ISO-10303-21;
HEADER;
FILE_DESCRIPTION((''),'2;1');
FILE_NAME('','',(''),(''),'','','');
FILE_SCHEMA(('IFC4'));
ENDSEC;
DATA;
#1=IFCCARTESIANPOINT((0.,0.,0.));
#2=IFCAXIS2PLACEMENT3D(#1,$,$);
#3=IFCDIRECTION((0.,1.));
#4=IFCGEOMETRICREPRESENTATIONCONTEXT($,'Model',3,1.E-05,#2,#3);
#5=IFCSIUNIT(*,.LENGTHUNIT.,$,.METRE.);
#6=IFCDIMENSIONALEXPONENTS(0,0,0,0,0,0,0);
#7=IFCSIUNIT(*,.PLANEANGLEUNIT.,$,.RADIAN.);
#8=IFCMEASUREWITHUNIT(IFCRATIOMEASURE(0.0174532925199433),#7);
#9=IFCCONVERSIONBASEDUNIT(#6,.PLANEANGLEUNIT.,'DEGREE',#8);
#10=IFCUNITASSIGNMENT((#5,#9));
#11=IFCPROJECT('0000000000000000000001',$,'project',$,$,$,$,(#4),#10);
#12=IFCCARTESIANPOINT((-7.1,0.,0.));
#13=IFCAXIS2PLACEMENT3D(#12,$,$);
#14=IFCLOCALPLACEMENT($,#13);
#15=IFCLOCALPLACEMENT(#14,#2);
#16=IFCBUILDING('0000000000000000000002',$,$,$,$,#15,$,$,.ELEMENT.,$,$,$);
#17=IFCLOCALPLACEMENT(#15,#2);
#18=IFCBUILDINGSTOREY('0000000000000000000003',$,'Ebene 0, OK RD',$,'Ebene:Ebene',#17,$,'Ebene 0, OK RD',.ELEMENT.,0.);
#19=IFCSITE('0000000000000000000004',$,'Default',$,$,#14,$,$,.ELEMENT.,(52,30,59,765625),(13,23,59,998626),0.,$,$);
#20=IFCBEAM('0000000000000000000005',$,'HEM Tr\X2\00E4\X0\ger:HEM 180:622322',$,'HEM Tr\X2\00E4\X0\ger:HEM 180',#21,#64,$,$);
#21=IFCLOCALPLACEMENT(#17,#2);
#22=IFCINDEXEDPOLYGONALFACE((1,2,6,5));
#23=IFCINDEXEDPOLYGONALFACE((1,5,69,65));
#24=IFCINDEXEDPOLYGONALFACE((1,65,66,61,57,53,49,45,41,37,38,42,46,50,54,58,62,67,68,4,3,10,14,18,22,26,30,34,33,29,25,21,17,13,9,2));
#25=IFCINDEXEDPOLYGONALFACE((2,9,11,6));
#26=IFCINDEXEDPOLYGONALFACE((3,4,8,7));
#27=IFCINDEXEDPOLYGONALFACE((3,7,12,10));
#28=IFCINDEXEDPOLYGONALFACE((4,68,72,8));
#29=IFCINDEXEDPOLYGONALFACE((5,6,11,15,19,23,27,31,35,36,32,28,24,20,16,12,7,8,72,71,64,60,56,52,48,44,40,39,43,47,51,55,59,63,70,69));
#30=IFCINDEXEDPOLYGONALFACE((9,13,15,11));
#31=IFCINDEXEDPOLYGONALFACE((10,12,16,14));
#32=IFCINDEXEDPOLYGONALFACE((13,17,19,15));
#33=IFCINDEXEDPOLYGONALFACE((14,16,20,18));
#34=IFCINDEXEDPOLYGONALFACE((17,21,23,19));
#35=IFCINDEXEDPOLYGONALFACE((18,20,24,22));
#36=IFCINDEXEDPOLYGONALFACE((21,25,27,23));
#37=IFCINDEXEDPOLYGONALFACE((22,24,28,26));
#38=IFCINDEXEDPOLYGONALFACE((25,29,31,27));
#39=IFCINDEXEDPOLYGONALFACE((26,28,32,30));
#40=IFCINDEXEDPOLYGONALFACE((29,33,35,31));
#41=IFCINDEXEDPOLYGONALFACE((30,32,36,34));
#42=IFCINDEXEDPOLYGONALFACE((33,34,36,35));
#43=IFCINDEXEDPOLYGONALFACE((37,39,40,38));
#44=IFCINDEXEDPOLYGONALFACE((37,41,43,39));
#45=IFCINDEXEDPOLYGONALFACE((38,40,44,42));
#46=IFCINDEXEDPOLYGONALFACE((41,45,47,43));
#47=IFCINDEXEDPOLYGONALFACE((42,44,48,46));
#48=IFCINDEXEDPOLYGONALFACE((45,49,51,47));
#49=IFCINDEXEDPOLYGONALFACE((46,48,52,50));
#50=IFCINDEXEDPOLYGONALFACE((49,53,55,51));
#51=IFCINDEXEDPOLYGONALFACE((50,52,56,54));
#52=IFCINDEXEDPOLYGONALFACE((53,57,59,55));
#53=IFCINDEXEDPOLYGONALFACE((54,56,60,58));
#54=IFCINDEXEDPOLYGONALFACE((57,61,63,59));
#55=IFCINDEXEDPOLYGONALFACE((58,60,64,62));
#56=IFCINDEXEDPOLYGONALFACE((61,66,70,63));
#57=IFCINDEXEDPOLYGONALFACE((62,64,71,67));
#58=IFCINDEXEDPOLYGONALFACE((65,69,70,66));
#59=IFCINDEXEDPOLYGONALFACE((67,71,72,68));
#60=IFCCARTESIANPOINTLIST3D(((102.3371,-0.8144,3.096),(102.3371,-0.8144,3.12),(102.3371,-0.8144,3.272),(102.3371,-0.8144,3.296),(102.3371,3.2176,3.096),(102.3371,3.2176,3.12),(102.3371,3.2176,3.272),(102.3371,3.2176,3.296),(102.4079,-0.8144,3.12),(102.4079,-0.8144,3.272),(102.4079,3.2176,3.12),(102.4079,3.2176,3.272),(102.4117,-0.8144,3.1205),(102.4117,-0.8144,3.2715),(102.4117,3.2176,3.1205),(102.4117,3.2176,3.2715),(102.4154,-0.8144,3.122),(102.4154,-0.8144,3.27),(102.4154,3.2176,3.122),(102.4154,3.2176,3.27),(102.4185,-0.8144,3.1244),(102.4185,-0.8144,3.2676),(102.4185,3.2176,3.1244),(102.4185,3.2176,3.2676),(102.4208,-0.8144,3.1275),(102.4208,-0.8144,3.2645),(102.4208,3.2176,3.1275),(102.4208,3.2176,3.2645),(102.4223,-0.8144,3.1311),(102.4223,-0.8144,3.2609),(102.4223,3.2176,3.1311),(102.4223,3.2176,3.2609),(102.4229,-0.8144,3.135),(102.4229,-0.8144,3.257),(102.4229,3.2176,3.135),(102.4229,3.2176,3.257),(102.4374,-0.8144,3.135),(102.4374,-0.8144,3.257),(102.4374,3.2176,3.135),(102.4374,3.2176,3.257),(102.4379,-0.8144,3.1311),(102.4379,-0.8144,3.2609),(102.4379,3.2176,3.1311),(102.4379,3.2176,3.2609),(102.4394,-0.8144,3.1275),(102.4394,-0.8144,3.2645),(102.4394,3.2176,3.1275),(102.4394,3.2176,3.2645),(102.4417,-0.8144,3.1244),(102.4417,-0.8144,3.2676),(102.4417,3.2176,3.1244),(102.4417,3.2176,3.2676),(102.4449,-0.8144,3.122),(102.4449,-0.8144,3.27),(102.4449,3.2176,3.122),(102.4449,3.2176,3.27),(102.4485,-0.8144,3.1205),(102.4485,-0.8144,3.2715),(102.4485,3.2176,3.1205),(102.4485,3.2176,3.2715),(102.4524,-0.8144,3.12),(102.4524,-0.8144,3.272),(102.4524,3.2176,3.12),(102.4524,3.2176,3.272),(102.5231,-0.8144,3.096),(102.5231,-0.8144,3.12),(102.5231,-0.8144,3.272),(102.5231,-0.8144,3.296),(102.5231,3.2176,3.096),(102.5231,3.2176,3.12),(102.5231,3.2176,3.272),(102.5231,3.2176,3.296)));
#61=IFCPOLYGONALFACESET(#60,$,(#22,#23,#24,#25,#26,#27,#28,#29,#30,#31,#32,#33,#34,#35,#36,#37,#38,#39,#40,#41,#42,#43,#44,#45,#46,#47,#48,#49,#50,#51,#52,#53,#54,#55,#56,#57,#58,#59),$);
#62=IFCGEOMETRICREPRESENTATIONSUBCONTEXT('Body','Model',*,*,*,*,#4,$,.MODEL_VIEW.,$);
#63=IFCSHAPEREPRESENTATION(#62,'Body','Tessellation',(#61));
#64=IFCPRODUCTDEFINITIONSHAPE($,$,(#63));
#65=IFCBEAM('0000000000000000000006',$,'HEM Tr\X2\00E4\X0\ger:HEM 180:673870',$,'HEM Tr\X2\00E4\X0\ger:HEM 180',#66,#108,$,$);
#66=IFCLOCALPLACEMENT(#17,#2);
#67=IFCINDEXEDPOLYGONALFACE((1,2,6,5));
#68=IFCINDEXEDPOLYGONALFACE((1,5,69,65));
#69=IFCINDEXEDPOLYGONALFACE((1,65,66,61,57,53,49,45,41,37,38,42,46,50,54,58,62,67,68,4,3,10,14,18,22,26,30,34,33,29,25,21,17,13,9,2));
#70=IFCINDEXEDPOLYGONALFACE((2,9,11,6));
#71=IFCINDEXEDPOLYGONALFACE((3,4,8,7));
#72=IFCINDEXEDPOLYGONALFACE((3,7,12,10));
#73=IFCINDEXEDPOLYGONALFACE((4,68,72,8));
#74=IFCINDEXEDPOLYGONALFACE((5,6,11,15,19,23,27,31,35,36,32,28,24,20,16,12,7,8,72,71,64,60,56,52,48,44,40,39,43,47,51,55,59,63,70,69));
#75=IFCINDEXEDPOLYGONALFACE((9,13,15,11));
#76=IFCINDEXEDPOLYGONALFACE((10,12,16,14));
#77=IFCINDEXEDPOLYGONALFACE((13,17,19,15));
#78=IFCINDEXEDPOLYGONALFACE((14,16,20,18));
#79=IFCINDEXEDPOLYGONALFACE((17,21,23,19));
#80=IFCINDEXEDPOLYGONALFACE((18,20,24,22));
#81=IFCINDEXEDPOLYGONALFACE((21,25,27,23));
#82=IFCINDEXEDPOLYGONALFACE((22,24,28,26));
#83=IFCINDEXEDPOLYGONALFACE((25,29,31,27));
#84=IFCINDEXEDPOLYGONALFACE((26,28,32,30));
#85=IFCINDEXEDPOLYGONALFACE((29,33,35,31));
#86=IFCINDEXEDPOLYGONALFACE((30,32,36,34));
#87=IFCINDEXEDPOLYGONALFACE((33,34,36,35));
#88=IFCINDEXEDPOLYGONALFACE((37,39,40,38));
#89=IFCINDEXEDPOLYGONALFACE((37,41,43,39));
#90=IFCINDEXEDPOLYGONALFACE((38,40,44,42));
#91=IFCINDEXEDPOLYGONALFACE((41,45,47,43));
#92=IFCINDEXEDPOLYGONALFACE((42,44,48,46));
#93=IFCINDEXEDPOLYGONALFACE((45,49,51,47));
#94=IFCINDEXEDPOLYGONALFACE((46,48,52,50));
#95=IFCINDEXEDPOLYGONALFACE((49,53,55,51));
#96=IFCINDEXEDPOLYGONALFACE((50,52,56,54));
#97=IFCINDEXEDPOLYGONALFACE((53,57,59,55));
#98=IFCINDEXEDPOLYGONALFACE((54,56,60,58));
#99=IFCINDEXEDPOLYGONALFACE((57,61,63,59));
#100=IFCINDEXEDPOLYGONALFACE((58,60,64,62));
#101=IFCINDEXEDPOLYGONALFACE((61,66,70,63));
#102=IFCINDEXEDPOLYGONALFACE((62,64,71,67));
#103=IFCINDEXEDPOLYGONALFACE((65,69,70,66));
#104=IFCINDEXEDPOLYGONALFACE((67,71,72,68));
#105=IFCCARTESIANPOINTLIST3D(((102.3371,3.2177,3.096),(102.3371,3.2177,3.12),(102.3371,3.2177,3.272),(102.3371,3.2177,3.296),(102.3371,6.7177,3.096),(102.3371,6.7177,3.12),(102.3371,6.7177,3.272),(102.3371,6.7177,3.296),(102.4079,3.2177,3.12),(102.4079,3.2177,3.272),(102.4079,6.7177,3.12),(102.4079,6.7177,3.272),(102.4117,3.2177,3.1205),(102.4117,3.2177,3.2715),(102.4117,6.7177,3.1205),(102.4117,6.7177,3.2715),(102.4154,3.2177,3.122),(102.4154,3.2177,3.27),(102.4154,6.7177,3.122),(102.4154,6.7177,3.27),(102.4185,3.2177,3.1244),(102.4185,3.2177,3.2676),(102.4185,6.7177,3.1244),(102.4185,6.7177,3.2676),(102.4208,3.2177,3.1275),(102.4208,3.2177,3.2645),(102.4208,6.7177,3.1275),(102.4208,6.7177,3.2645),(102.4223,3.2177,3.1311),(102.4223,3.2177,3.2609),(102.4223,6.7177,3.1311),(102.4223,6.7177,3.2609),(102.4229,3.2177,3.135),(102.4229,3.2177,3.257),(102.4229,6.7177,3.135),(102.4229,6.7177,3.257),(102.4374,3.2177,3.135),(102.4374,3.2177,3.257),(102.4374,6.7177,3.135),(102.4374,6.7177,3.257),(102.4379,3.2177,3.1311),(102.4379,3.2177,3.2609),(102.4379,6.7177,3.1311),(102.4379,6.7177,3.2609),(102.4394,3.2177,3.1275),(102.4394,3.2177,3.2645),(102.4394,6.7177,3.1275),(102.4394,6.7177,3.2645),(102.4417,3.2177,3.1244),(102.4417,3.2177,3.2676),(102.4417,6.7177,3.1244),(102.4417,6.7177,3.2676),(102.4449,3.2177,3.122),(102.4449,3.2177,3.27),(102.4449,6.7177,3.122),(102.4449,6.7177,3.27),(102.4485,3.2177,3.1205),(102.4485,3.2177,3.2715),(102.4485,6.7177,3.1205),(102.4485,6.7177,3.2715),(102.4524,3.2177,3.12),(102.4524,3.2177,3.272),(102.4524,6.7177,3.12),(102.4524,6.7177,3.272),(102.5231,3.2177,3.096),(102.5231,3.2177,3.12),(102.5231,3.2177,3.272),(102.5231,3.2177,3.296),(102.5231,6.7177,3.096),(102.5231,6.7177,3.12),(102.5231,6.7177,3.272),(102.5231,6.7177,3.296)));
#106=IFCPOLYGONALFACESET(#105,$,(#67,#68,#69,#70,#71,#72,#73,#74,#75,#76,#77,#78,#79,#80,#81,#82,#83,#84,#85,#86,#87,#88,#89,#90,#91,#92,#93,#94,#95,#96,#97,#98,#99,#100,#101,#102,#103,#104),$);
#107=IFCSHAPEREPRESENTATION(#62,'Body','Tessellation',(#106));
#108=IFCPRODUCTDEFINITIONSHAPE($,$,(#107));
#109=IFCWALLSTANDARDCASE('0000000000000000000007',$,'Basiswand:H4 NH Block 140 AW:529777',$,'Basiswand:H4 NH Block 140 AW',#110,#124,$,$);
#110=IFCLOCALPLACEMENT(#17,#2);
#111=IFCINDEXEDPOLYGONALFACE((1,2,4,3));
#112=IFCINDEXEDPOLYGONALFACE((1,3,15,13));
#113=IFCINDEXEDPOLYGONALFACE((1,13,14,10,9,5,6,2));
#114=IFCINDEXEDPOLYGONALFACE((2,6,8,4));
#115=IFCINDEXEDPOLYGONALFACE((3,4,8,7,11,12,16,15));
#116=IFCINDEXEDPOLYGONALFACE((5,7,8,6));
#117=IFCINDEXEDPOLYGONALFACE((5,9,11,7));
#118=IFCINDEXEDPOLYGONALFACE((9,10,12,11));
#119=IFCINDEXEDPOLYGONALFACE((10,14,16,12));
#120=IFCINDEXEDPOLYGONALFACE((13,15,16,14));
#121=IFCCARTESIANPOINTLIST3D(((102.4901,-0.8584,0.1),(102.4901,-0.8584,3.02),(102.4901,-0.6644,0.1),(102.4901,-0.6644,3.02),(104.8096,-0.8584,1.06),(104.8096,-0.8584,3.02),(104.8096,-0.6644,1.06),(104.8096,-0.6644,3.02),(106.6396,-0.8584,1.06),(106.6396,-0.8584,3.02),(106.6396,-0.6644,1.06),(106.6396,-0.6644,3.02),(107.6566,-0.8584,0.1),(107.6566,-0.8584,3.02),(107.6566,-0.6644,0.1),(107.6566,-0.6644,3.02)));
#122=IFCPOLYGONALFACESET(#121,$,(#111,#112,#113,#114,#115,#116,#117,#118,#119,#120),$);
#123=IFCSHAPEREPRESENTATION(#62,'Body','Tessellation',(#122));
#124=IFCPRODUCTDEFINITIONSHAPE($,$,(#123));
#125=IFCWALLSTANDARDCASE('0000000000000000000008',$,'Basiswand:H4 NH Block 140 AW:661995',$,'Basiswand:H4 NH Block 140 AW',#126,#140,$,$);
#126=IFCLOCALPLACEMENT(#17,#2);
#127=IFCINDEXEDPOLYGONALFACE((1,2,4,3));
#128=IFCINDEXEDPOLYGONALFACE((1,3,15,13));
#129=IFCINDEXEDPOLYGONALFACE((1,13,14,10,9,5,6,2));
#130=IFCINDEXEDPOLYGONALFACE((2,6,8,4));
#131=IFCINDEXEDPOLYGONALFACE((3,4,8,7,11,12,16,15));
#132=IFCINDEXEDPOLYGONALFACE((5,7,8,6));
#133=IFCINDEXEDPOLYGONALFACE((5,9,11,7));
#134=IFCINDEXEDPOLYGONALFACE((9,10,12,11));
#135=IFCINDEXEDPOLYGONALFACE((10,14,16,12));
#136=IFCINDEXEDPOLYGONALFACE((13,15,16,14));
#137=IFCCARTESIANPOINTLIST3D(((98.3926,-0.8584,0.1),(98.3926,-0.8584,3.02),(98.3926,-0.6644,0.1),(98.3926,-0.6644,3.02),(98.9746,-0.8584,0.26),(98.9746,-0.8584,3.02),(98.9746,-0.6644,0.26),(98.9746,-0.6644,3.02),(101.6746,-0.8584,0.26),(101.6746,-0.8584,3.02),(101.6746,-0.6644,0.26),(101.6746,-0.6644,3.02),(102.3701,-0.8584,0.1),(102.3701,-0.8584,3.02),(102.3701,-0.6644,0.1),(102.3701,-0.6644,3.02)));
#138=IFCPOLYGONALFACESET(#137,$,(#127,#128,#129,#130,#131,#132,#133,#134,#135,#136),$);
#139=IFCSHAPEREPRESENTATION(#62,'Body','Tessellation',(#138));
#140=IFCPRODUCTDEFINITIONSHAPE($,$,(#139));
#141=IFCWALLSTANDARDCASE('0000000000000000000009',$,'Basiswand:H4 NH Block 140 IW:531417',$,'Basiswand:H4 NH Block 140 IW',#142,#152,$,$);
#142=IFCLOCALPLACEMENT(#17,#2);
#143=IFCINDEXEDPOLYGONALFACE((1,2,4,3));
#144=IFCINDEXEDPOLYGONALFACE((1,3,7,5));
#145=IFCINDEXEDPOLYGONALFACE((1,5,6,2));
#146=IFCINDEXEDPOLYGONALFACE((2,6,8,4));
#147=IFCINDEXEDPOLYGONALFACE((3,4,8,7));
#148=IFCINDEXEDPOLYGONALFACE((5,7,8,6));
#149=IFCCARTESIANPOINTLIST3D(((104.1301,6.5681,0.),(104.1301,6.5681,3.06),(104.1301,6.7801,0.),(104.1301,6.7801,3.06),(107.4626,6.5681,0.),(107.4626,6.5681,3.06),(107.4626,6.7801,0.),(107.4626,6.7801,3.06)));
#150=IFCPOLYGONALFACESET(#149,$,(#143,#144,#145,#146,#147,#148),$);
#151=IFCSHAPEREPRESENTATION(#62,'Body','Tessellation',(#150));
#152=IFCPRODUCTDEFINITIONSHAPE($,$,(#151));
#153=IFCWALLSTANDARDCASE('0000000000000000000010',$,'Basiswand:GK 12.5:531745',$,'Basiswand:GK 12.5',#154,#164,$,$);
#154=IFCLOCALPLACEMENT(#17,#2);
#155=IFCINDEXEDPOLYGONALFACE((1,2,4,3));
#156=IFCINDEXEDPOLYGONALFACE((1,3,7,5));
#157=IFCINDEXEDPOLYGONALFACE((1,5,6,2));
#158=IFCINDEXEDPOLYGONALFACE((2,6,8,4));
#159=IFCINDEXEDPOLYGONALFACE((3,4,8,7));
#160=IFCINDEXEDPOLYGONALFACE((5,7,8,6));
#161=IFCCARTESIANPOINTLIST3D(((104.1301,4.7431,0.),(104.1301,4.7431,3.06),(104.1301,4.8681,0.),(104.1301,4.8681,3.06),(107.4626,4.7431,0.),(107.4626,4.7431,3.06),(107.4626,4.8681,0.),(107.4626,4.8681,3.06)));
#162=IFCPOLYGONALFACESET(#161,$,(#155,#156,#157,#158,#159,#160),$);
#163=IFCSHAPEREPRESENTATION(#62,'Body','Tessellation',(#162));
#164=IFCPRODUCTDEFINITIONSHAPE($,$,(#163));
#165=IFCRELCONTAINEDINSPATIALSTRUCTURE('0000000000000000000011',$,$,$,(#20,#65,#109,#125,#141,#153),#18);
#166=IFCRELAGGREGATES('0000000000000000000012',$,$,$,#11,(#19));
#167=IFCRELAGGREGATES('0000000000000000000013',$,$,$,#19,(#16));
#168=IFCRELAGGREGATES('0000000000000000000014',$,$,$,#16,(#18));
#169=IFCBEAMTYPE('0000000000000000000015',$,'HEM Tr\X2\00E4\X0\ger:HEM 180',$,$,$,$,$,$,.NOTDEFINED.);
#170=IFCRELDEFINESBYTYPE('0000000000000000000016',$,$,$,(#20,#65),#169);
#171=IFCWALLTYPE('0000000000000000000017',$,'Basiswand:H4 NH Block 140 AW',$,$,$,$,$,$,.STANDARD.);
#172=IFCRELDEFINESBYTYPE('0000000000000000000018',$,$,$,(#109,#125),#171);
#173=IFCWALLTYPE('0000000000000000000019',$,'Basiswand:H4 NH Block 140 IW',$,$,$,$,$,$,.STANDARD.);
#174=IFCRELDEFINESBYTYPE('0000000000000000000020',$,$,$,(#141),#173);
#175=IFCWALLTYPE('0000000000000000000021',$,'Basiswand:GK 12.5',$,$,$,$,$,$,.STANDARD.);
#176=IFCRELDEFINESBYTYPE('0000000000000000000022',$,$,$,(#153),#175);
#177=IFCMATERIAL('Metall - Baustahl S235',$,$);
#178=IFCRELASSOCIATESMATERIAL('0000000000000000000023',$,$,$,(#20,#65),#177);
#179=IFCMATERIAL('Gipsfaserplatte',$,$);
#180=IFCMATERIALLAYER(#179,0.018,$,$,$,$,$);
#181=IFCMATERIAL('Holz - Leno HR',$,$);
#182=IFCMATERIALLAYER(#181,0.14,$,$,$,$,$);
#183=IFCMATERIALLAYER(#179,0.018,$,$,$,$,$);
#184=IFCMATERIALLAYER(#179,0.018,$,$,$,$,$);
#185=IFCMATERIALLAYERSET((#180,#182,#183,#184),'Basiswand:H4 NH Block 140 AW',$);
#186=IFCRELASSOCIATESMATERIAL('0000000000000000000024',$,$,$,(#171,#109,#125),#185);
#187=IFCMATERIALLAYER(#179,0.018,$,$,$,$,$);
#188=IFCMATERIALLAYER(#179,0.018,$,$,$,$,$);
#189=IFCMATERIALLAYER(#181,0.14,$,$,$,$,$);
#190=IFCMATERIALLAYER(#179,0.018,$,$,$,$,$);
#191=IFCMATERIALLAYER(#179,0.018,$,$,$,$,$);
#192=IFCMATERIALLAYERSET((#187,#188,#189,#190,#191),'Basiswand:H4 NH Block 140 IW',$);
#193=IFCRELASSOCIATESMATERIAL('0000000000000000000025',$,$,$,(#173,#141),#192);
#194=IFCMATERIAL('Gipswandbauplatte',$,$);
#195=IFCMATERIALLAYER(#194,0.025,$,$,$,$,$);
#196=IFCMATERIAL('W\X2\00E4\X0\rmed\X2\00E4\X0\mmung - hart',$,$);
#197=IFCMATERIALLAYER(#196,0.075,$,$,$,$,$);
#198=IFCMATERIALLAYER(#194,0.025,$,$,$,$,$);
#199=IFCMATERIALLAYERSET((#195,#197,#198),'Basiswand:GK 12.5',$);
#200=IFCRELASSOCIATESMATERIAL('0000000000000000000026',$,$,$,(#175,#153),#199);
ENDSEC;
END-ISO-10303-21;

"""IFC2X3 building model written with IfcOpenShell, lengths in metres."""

from ifc_helpers import new_model, entity, si_unit, converted_unit, direction, frame, frame_2d, origin, origin_2d_with_axis, place, context, subcontext, project, spatial, rectangle, i_section, extrude, material, layer, layer_set, layer_usage, type_object, element, save


model = new_model("IFC2X3")

# Units and contexts
model_context = context("Model", 3, precision=1e-05, world=origin(), true_north=direction((0.0, 1.0)))
body_context = subcontext(model_context, "Body", "Model", "MODEL_VIEW")
ifc_project = project(units=[si_unit("LENGTHUNIT", "METRE"), converted_unit("PLANEANGLEUNIT", "DEGREE", entity("IfcRatioMeasure", 0.0174532925199433), si_unit("PLANEANGLEUNIT", "RADIAN"), dimensions=[0, 0, 0, 0, 0, 0, 0])], contexts=[model_context])

# Site, building, storey
site_placement = place(None, frame((-7.1, 0.0, 0.0)))
site = spatial("IfcSite", under=ifc_project, at=site_placement, Name="Default", CompositionType="ELEMENT", RefLatitude=(52, 30, 59, 765625), RefLongitude=(13, 23, 59, 998626), RefElevation=0.0)
building_placement = place(site_placement, origin())
building = spatial("IfcBuilding", under=site, at=building_placement, CompositionType="ELEMENT")
storey_placement = place(building_placement, origin())
storey = spatial("IfcBuildingStorey", under=building, at=storey_placement, Name="Ebene 0, OK RD", ObjectType="Ebene:Ebene", LongName="Ebene 0, OK RD", CompositionType="ELEMENT", Elevation=0.0)

# Shared definitions
ifc_material_1 = material(Name="Metall - Baustahl S235")

# Beams
beam_type = type_object("IfcBeamType", Name="HEM Träger:HEM 180", PredefinedType="NOTDEFINED")
beam_1_placement = place(storey_placement, frame((102.4301, -0.8144, 3.096), z_axis=(0.0, 0.0, 1.0), x_axis=(0.0, 1.0, 0.0)))
element("IfcBeam", 1, at=beam_1_placement, inside=storey, type_object=beam_type, material=ifc_material_1, Name="HEM Träger:HEM 180:622322", ObjectType="HEM Träger:HEM 180", context=body_context, shape_type="SweptSolid", body=[
    extrude(i_section(OverallWidth=0.186, OverallDepth=0.2, WebThickness=0.0145, FlangeThickness=0.024, FilletRadius=0.015, at=frame_2d((0.0, 0.0), x_axis=(0.0, 1.0))), frame((0.0, 0.0, 0.1), z_axis=(1.0, 0.0, 0.0), x_axis=(0.0, 0.0, -1.0)), (0.0, 0.0, 1.0), 4.032),
])
beam_2_placement = place(storey_placement, frame((102.4301, 3.2176, 3.096), z_axis=(0.0, 0.0, 1.0), x_axis=(0.0, 1.0, 0.0)))
element("IfcBeam", 2, at=beam_2_placement, inside=storey, type_object=beam_type, material=ifc_material_1, Name="HEM Träger:HEM 180:673870", ObjectType="HEM Träger:HEM 180", context=body_context, shape_type="SweptSolid", body=[
    extrude(i_section(OverallWidth=0.186, OverallDepth=0.2, WebThickness=0.0145, FlangeThickness=0.024, FilletRadius=0.015, at=frame_2d((0.0, 0.0), x_axis=(0.0, 1.0))), frame((0.0, 0.0, 0.1), z_axis=(1.0, 0.0, 0.0), x_axis=(0.0, 0.0, -1.0)), (0.0, 0.0, 1.0), 3.5),
])

# Walls, openings
ifc_material_2 = material(Name="Gipsfaserplatte")
ifc_layer_1 = layer(ifc_material_2, 0.018)
ifc_material_3 = material(Name="Holz - Leno HR")
ifc_layer_2 = layer(ifc_material_3, 0.14)
ifc_layer_3 = layer(ifc_material_2, 0.018)
ifc_layer_4 = layer(ifc_material_2, 0.018)
ifc_layer_set_1 = layer_set([ifc_layer_1, ifc_layer_2, ifc_layer_3, ifc_layer_4], Name="Basiswand:H4 NH Block 140 AW")
ifc_layer_usage_1 = layer_usage(ifc_layer_set_1, "AXIS2", "NEGATIVE", 0.097)
wall_type_1 = type_object("IfcWallType", Name="Basiswand:H4 NH Block 140 AW", PredefinedType="STANDARD", material=ifc_layer_set_1)
wall_1_placement = place(storey_placement, frame((107.6566, -0.7614, 0.1), z_axis=(0.0, 0.0, 1.0), x_axis=(-1.0, 0.0, 0.0)))
wall_1 = element("IfcWallStandardCase", 3, at=wall_1_placement, inside=storey, type_object=wall_type_1, material=ifc_layer_usage_1, Name="Basiswand:H4 NH Block 140 AW:529777", ObjectType="Basiswand:H4 NH Block 140 AW", context=body_context, shape_type="SweptSolid", body=[
    extrude(rectangle(XDim=5.1665, YDim=0.194, at=frame_2d((2.5833, 0.0), x_axis=(-1.0, 0.0))), origin(), (0.0, 0.0, 1.0), 2.92),
])
opening_1_placement = place(wall_1_placement, origin())
element("IfcOpeningElement", 4, at=opening_1_placement, cuts=wall_1, ObjectType="Opening", context=body_context, shape_type="SweptSolid", body=[
    extrude(rectangle(XDim=2.0, YDim=1.83, at=origin_2d_with_axis()), frame((1.932, -0.097, 1.96), z_axis=(0.0, 1.0, 0.0), x_axis=(0.0, 0.0, -1.0)), (0.0, 0.0, 1.0), 0.194),
])
ifc_layer_usage_2 = layer_usage(ifc_layer_set_1, "AXIS2", "NEGATIVE", 0.097)
wall_2_placement = place(storey_placement, frame((102.3701, -0.7614, 0.1), z_axis=(0.0, 0.0, 1.0), x_axis=(-1.0, 0.0, 0.0)))
wall_2 = element("IfcWallStandardCase", 5, at=wall_2_placement, inside=storey, type_object=wall_type_1, material=ifc_layer_usage_2, Name="Basiswand:H4 NH Block 140 AW:661995", ObjectType="Basiswand:H4 NH Block 140 AW", context=body_context, shape_type="SweptSolid", body=[
    extrude(rectangle(XDim=3.9775, YDim=0.194, at=frame_2d((1.9888, 0.0), x_axis=(-1.0, 0.0))), origin(), (0.0, 0.0, 1.0), 2.92),
])
opening_2_placement = place(wall_2_placement, origin())
element("IfcOpeningElement", 6, at=opening_2_placement, cuts=wall_2, ObjectType="Opening", context=body_context, shape_type="SweptSolid", body=[
    extrude(rectangle(XDim=2.8, YDim=2.7, at=origin_2d_with_axis()), frame((2.0455, -0.097, 1.56), z_axis=(0.0, 1.0, 0.0), x_axis=(0.0, 0.0, -1.0)), (0.0, 0.0, 1.0), 0.194),
])

# Walls
ifc_layer_5 = layer(ifc_material_2, 0.018)
ifc_layer_6 = layer(ifc_material_2, 0.018)
ifc_layer_7 = layer(ifc_material_3, 0.14)
ifc_layer_8 = layer(ifc_material_2, 0.018)
ifc_layer_9 = layer(ifc_material_2, 0.018)
ifc_layer_set_2 = layer_set([ifc_layer_5, ifc_layer_6, ifc_layer_7, ifc_layer_8, ifc_layer_9], Name="Basiswand:H4 NH Block 140 IW")
ifc_layer_usage_3 = layer_usage(ifc_layer_set_2, "AXIS2", "NEGATIVE", 0.106)
wall_type_2 = type_object("IfcWallType", Name="Basiswand:H4 NH Block 140 IW", PredefinedType="STANDARD", material=ifc_layer_set_2)
wall_3_placement = place(storey_placement, frame((104.1301, 6.6741, 0.0)))
element("IfcWallStandardCase", 7, at=wall_3_placement, inside=storey, type_object=wall_type_2, material=ifc_layer_usage_3, Name="Basiswand:H4 NH Block 140 IW:531417", ObjectType="Basiswand:H4 NH Block 140 IW", context=body_context, shape_type="SweptSolid", body=[
    extrude(rectangle(XDim=3.3325, YDim=0.212, at=frame_2d((1.6663, 0.0), x_axis=(-1.0, 0.0))), origin(), (0.0, 0.0, 1.0), 3.06),
])
ifc_material_4 = material(Name="Gipswandbauplatte")
ifc_layer_10 = layer(ifc_material_4, 0.025)
ifc_material_5 = material(Name="Wärmedämmung - hart")
ifc_layer_11 = layer(ifc_material_5, 0.075)
ifc_layer_12 = layer(ifc_material_4, 0.025)
ifc_layer_set_3 = layer_set([ifc_layer_10, ifc_layer_11, ifc_layer_12], Name="Basiswand:GK 12.5")
ifc_layer_usage_4 = layer_usage(ifc_layer_set_3, "AXIS2", "NEGATIVE", 0.0625)
wall_type_3 = type_object("IfcWallType", Name="Basiswand:GK 12.5", PredefinedType="STANDARD", material=ifc_layer_set_3)
wall_4_placement = place(storey_placement, frame((104.1301, 4.8056, 0.0)))
element("IfcWallStandardCase", 8, at=wall_4_placement, inside=storey, type_object=wall_type_3, material=ifc_layer_usage_4, Name="Basiswand:GK 12.5:531745", ObjectType="Basiswand:GK 12.5", context=body_context, shape_type="SweptSolid", body=[
    extrude(rectangle(XDim=3.3325, YDim=0.125, at=frame_2d((1.6663, 0.0), x_axis=(-1.0, 0.0))), origin(), (0.0, 0.0, 1.0), 3.06),
])

save(model, "model.ifc")
